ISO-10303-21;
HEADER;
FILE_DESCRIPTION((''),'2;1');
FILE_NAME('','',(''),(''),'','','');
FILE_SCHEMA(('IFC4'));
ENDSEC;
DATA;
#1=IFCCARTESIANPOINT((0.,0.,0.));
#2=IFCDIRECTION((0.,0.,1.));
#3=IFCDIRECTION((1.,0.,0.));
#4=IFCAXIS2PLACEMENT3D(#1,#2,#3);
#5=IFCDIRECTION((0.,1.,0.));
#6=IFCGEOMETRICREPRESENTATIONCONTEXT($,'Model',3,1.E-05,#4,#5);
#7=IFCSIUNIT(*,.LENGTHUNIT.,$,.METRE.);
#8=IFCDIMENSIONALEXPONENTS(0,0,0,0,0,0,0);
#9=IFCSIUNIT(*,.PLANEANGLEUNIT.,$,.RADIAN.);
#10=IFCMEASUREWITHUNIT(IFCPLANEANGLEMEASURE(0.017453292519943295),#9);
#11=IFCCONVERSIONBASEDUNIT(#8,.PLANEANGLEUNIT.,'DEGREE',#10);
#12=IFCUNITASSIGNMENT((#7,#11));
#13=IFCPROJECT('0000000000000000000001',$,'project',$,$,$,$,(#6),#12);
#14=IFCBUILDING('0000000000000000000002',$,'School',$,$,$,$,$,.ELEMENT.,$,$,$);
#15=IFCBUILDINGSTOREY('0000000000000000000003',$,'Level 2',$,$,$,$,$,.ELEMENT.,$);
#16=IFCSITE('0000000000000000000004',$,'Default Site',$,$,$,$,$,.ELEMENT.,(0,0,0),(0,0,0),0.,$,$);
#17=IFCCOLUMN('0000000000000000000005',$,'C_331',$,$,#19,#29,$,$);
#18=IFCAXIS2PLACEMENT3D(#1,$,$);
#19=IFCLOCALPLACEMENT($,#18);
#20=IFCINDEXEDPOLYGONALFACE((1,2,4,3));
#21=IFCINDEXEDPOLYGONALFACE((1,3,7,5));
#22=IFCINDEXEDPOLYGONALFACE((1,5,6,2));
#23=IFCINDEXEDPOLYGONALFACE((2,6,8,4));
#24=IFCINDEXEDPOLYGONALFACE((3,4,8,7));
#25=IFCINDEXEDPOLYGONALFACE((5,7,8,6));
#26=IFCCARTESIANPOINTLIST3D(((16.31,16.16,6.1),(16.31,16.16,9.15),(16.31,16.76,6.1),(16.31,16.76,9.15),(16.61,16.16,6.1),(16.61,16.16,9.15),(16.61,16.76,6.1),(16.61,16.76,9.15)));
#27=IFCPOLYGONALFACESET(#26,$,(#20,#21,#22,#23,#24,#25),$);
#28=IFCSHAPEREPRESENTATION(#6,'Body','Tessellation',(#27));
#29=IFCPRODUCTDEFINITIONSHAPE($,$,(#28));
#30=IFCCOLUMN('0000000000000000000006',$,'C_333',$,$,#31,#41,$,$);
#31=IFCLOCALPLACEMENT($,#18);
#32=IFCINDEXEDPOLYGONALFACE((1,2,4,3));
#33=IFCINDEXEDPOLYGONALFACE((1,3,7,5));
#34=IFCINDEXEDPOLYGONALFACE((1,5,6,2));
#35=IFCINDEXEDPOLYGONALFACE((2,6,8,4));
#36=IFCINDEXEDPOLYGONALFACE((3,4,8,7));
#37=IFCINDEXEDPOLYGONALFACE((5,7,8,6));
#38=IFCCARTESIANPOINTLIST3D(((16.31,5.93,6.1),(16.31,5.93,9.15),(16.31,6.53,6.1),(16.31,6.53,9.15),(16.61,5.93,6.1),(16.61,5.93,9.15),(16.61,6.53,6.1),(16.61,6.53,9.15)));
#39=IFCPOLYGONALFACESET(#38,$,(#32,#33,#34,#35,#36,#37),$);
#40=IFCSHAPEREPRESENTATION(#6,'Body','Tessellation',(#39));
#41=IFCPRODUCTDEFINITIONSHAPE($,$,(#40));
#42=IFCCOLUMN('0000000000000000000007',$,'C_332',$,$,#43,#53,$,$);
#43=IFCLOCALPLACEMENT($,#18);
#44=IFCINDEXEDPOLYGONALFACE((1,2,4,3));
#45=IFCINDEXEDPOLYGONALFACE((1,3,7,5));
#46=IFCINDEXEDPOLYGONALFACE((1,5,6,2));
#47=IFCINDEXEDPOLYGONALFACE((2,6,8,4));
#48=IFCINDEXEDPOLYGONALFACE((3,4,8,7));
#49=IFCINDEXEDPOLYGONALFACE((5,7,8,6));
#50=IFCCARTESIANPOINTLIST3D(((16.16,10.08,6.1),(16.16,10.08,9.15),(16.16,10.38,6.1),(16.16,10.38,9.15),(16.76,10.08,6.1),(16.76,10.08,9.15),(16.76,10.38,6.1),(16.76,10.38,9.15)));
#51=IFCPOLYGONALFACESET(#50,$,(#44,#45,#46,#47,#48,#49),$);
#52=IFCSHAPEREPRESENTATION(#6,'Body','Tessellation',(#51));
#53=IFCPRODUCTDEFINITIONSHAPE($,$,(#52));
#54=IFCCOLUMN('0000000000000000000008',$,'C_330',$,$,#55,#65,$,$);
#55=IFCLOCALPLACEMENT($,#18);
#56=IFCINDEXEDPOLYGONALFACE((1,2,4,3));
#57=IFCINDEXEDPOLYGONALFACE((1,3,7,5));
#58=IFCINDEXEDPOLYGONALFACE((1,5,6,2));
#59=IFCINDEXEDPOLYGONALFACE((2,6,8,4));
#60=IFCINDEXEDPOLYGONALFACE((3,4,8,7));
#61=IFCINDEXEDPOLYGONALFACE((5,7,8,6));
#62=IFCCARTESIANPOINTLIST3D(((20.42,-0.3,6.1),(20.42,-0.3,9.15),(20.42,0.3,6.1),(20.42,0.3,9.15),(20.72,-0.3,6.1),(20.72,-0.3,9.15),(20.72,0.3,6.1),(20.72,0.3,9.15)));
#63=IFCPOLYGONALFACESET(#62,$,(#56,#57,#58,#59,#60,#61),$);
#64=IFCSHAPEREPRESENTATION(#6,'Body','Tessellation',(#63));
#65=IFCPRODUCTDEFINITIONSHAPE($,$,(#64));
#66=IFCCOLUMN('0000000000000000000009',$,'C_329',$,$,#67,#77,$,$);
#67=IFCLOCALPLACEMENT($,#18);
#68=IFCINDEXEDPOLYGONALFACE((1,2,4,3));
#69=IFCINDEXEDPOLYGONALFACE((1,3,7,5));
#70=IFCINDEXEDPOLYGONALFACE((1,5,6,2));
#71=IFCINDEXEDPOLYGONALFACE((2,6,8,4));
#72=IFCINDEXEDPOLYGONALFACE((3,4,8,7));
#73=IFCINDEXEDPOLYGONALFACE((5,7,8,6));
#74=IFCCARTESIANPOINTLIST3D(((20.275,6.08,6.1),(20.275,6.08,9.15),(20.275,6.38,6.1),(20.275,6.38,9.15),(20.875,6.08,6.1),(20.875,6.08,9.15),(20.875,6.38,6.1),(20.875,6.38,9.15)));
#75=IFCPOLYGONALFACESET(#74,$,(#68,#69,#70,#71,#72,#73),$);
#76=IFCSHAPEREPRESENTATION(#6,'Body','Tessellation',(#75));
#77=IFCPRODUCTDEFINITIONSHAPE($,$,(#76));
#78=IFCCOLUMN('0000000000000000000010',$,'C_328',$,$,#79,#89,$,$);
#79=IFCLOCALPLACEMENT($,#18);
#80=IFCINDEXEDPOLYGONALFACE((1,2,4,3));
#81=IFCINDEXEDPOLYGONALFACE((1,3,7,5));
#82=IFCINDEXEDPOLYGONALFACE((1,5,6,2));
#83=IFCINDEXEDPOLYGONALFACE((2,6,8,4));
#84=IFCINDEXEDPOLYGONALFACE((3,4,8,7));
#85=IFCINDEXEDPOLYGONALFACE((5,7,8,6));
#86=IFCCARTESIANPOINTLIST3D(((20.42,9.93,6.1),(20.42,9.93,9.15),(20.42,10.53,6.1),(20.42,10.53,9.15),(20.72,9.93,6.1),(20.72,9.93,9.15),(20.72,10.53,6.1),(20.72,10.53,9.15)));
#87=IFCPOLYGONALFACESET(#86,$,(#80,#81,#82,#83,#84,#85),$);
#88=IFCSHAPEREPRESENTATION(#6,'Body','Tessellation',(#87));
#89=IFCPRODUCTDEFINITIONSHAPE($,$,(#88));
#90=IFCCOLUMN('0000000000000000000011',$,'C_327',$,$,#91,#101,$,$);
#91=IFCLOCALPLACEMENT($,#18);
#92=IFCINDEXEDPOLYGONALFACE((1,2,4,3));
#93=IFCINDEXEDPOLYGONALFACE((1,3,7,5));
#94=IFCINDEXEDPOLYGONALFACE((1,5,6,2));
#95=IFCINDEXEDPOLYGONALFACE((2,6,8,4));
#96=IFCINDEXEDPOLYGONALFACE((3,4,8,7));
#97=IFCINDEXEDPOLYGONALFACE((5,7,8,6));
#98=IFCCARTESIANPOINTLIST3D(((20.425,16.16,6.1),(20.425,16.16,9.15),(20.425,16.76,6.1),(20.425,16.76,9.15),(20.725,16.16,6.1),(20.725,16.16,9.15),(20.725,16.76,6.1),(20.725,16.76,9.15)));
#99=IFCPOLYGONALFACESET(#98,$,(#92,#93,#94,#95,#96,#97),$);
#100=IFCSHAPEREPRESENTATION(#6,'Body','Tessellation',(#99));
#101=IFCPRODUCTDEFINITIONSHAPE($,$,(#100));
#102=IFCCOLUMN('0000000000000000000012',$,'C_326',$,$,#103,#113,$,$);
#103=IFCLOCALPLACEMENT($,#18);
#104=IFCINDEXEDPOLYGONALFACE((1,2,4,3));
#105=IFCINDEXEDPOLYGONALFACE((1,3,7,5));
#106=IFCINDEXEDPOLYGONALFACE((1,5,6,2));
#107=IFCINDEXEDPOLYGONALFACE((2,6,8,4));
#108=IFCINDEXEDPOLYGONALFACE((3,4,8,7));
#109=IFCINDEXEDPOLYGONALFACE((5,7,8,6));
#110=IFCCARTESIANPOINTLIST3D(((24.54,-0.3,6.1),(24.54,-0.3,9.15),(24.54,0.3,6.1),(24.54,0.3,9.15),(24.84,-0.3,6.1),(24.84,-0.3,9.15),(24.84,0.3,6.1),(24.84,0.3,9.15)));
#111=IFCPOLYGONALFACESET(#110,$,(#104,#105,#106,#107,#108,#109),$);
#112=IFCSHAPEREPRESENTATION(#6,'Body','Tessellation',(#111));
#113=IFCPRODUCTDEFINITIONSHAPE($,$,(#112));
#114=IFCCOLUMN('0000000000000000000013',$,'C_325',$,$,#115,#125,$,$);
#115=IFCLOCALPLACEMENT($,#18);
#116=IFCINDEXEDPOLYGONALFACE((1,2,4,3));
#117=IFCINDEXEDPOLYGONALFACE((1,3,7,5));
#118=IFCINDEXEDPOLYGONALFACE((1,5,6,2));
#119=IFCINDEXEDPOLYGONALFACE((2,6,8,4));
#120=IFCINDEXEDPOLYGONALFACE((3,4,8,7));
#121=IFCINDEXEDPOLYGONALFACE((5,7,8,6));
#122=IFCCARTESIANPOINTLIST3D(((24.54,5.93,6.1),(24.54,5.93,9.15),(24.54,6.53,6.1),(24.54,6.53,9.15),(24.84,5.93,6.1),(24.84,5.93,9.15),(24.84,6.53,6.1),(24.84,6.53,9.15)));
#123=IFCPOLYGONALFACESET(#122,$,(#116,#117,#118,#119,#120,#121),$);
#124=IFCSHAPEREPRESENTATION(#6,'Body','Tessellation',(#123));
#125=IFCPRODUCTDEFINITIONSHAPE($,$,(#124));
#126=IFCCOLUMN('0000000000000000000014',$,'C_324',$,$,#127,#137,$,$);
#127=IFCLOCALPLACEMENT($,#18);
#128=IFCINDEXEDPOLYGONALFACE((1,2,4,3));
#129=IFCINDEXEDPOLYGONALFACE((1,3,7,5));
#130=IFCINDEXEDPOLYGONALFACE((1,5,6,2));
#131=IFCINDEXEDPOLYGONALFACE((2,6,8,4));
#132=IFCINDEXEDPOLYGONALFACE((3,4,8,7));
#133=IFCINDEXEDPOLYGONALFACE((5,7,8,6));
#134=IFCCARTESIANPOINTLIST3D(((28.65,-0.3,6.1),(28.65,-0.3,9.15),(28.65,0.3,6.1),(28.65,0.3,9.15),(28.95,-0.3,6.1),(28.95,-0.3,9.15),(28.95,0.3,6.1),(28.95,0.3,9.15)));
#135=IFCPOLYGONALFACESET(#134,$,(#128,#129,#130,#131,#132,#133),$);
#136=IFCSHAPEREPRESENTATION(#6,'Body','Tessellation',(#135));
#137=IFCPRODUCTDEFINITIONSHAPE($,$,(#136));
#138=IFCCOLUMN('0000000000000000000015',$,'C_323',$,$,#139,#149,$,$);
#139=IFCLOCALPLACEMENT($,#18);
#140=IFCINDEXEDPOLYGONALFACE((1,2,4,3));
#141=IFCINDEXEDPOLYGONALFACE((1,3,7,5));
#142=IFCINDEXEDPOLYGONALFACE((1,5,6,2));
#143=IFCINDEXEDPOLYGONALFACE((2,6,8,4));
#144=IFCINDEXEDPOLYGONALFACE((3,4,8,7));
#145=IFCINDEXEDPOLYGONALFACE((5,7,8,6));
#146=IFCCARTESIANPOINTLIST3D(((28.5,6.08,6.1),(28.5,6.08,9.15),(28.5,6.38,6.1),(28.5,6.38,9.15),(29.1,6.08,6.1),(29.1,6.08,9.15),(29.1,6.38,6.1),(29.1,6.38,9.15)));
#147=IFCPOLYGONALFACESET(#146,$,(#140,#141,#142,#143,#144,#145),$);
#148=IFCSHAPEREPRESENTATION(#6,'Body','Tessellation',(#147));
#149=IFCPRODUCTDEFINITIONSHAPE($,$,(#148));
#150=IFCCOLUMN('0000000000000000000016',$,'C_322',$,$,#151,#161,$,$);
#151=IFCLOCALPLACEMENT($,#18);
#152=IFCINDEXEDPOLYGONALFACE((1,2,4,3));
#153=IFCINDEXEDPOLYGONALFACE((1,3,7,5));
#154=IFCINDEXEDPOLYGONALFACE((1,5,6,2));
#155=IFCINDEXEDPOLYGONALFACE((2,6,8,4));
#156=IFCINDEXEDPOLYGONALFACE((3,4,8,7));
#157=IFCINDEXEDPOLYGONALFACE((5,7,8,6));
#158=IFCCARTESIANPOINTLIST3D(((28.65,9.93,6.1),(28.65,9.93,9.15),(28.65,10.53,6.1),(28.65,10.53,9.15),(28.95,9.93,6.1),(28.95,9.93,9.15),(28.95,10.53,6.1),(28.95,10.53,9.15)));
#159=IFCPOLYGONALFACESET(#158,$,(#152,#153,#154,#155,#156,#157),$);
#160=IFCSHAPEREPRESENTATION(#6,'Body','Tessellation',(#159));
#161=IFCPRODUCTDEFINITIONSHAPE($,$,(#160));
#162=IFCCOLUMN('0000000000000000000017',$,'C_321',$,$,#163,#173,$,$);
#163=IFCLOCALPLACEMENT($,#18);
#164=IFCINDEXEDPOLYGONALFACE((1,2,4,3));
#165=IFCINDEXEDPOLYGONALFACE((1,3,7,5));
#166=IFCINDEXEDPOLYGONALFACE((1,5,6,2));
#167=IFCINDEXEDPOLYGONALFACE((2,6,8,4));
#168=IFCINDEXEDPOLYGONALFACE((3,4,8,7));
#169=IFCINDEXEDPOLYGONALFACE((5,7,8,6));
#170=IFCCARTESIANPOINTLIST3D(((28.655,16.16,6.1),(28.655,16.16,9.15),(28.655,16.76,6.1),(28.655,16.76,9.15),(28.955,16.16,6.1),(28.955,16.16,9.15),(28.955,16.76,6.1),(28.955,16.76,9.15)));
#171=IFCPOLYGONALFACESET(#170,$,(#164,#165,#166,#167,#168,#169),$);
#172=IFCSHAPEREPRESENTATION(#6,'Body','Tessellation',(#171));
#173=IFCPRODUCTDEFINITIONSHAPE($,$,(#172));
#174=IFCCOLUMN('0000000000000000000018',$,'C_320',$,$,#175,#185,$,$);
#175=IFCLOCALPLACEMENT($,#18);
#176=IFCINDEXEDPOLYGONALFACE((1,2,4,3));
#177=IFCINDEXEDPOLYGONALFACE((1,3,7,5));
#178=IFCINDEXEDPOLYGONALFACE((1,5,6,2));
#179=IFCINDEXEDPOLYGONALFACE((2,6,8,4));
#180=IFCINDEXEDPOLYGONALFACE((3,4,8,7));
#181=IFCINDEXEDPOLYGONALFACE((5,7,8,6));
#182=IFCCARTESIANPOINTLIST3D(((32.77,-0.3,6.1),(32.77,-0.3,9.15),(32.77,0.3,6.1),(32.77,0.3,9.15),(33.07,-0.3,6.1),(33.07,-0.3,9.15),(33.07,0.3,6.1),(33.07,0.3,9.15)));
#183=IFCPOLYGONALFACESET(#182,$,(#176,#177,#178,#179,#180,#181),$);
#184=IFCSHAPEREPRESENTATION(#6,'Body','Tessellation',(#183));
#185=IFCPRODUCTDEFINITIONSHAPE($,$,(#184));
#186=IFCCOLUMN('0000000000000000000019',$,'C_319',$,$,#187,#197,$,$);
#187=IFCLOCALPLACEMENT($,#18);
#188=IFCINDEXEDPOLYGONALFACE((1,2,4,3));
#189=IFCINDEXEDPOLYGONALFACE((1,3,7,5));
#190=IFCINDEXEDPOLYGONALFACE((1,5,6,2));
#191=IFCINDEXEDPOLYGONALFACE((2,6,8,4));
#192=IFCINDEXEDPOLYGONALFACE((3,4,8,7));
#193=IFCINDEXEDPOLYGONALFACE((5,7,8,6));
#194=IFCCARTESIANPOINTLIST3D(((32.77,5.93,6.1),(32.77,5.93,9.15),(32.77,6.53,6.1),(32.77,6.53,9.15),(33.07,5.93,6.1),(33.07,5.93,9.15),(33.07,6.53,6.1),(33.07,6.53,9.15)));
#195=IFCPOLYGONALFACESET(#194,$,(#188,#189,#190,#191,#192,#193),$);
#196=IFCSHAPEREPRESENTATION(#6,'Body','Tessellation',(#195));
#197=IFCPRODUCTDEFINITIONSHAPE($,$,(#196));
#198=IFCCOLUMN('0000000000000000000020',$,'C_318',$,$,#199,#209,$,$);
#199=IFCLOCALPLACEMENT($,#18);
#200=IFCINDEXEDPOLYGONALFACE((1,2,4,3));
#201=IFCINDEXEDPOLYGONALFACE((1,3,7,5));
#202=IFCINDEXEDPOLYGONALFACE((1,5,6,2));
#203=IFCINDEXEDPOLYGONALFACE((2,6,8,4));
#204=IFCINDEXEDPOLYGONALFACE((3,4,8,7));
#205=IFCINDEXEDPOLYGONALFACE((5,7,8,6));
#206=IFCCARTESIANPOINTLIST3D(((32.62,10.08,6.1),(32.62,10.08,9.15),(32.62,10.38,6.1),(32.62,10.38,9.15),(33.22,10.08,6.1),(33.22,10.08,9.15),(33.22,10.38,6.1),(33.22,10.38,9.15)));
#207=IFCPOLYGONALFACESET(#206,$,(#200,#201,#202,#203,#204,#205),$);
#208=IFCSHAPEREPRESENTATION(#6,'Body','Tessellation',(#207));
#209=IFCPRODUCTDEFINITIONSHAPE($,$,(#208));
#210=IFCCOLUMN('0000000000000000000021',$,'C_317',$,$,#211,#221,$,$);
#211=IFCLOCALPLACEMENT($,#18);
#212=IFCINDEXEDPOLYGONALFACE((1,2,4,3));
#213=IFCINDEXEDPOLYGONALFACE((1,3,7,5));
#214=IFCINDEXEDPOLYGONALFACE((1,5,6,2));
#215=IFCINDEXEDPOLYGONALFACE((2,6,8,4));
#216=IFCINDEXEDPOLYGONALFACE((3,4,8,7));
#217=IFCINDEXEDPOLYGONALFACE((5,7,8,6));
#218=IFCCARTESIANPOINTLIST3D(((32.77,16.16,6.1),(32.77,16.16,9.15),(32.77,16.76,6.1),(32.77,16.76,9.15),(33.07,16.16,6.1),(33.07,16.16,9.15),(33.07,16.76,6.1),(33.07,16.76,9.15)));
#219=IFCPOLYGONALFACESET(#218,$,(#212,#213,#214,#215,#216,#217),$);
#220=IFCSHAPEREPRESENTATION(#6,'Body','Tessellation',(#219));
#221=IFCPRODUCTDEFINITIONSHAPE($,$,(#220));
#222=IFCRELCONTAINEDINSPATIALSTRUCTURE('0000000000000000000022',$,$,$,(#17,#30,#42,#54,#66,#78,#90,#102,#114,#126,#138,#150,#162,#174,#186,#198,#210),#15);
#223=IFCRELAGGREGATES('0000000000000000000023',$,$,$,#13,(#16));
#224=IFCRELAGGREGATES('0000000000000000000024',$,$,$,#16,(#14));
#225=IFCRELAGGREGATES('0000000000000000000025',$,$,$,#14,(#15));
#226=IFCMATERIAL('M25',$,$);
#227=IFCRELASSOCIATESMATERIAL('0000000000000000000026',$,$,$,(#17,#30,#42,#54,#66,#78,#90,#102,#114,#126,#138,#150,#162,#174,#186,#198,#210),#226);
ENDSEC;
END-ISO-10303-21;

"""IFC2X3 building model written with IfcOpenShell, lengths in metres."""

from ifc_helpers import new_model, entity, si_unit, converted_unit, direction, frame, frame_2d, origin_with_axes, place, context, project, spatial, rectangle, extrude, material, element, save


model = new_model("IFC2X3")

# Units and contexts
model_context = context("Model", 3, precision=1e-05, world=origin_with_axes(), true_north=direction((0.0, 1.0, 0.0)))
ifc_project = project(units=[si_unit("LENGTHUNIT", "METRE"), converted_unit("PLANEANGLEUNIT", "DEGREE", entity("IfcPlaneAngleMeasure", 0.017453292519943295), si_unit("PLANEANGLEUNIT", "RADIAN"), dimensions=[0, 0, 0, 0, 0, 0, 0])], contexts=[model_context])

# Site, building, storey
site = spatial("IfcSite", under=ifc_project, Name="Default Site", CompositionType="ELEMENT", RefLatitude=(0, 0, 0), RefLongitude=(0, 0, 0), RefElevation=0.0)
building = spatial("IfcBuilding", under=site, Name="School", CompositionType="ELEMENT")
storey = spatial("IfcBuildingStorey", under=building, Name="Level 2", CompositionType="ELEMENT")

# Columns
ifc_material = material(Name="M25")
placement = place(None, origin_with_axes())
element("IfcColumn", 1, at=placement, inside=storey, material=ifc_material, Name="C_331", context=model_context, shape_type="SweptSolid", body=[
    extrude(rectangle(XDim=0.3, YDim=0.6, at=frame_2d((0.0, 0.0), x_axis=(1.0, 0.0, 0.0))), frame((16.46, 16.46, 6.1), z_axis=(0.0, 0.0, 1.0), x_axis=(1.0, 0.0, 0.0)), (0.0, 0.0, 1.0), 3.05),
])
element("IfcColumn", 2, at=placement, inside=storey, material=ifc_material, Name="C_333", context=model_context, shape_type="SweptSolid", body=[
    extrude(rectangle(XDim=0.3, YDim=0.6, at=frame_2d((0.0, 0.0), x_axis=(1.0, 0.0, 0.0))), frame((16.46, 6.23, 6.1), z_axis=(0.0, 0.0, 1.0), x_axis=(1.0, 0.0, 0.0)), (0.0, 0.0, 1.0), 3.05),
])
element("IfcColumn", 3, at=placement, inside=storey, material=ifc_material, Name="C_332", context=model_context, shape_type="SweptSolid", body=[
    extrude(rectangle(XDim=0.6, YDim=0.3, at=frame_2d((0.0, 0.0), x_axis=(1.0, 0.0, 0.0))), frame((16.46, 10.23, 6.1), z_axis=(0.0, 0.0, 1.0), x_axis=(1.0, 0.0, 0.0)), (0.0, 0.0, 1.0), 3.05),
])
element("IfcColumn", 4, at=placement, inside=storey, material=ifc_material, Name="C_330", context=model_context, shape_type="SweptSolid", body=[
    extrude(rectangle(XDim=0.3, YDim=0.6, at=frame_2d((0.0, 0.0), x_axis=(1.0, 0.0, 0.0))), frame((20.57, 0.0, 6.1), z_axis=(0.0, 0.0, 1.0), x_axis=(1.0, 0.0, 0.0)), (0.0, 0.0, 1.0), 3.05),
])
element("IfcColumn", 5, at=placement, inside=storey, material=ifc_material, Name="C_329", context=model_context, shape_type="SweptSolid", body=[
    extrude(rectangle(XDim=0.6, YDim=0.3, at=frame_2d((0.0, 0.0), x_axis=(1.0, 0.0, 0.0))), frame((20.575, 6.23, 6.1), z_axis=(0.0, 0.0, 1.0), x_axis=(1.0, 0.0, 0.0)), (0.0, 0.0, 1.0), 3.05),
])
element("IfcColumn", 6, at=placement, inside=storey, material=ifc_material, Name="C_328", context=model_context, shape_type="SweptSolid", body=[
    extrude(rectangle(XDim=0.3, YDim=0.6, at=frame_2d((0.0, 0.0), x_axis=(1.0, 0.0, 0.0))), frame((20.57, 10.23, 6.1), z_axis=(0.0, 0.0, 1.0), x_axis=(1.0, 0.0, 0.0)), (0.0, 0.0, 1.0), 3.05),
])
element("IfcColumn", 7, at=placement, inside=storey, material=ifc_material, Name="C_327", context=model_context, shape_type="SweptSolid", body=[
    extrude(rectangle(XDim=0.3, YDim=0.6, at=frame_2d((0.0, 0.0), x_axis=(1.0, 0.0, 0.0))), frame((20.575, 16.46, 6.1), z_axis=(0.0, 0.0, 1.0), x_axis=(1.0, 0.0, 0.0)), (0.0, 0.0, 1.0), 3.05),
])
element("IfcColumn", 8, at=placement, inside=storey, material=ifc_material, Name="C_326", context=model_context, shape_type="SweptSolid", body=[
    extrude(rectangle(XDim=0.3, YDim=0.6, at=frame_2d((0.0, 0.0), x_axis=(1.0, 0.0, 0.0))), frame((24.69, 0.0, 6.1), z_axis=(0.0, 0.0, 1.0), x_axis=(1.0, 0.0, 0.0)), (0.0, 0.0, 1.0), 3.05),
])
element("IfcColumn", 9, at=placement, inside=storey, material=ifc_material, Name="C_325", context=model_context, shape_type="SweptSolid", body=[
    extrude(rectangle(XDim=0.3, YDim=0.6, at=frame_2d((0.0, 0.0), x_axis=(1.0, 0.0, 0.0))), frame((24.69, 6.23, 6.1), z_axis=(0.0, 0.0, 1.0), x_axis=(1.0, 0.0, 0.0)), (0.0, 0.0, 1.0), 3.05),
])
element("IfcColumn", 10, at=placement, inside=storey, material=ifc_material, Name="C_324", context=model_context, shape_type="SweptSolid", body=[
    extrude(rectangle(XDim=0.3, YDim=0.6, at=frame_2d((0.0, 0.0), x_axis=(1.0, 0.0, 0.0))), frame((28.8, 0.0, 6.1), z_axis=(0.0, 0.0, 1.0), x_axis=(1.0, 0.0, 0.0)), (0.0, 0.0, 1.0), 3.05),
])
element("IfcColumn", 11, at=placement, inside=storey, material=ifc_material, Name="C_323", context=model_context, shape_type="SweptSolid", body=[
    extrude(rectangle(XDim=0.6, YDim=0.3, at=frame_2d((0.0, 0.0), x_axis=(1.0, 0.0, 0.0))), frame((28.8, 6.23, 6.1), z_axis=(0.0, 0.0, 1.0), x_axis=(1.0, 0.0, 0.0)), (0.0, 0.0, 1.0), 3.05),
])
element("IfcColumn", 12, at=placement, inside=storey, material=ifc_material, Name="C_322", context=model_context, shape_type="SweptSolid", body=[
    extrude(rectangle(XDim=0.3, YDim=0.6, at=frame_2d((0.0, 0.0), x_axis=(1.0, 0.0, 0.0))), frame((28.8, 10.23, 6.1), z_axis=(0.0, 0.0, 1.0), x_axis=(1.0, 0.0, 0.0)), (0.0, 0.0, 1.0), 3.05),
])
element("IfcColumn", 13, at=placement, inside=storey, material=ifc_material, Name="C_321", context=model_context, shape_type="SweptSolid", body=[
    extrude(rectangle(XDim=0.3, YDim=0.6, at=frame_2d((0.0, 0.0), x_axis=(1.0, 0.0, 0.0))), frame((28.805, 16.46, 6.1), z_axis=(0.0, 0.0, 1.0), x_axis=(1.0, 0.0, 0.0)), (0.0, 0.0, 1.0), 3.05),
])
element("IfcColumn", 14, at=placement, inside=storey, material=ifc_material, Name="C_320", context=model_context, shape_type="SweptSolid", body=[
    extrude(rectangle(XDim=0.3, YDim=0.6, at=frame_2d((0.0, 0.0), x_axis=(1.0, 0.0, 0.0))), frame((32.92, 0.0, 6.1), z_axis=(0.0, 0.0, 1.0), x_axis=(1.0, 0.0, 0.0)), (0.0, 0.0, 1.0), 3.05),
])
element("IfcColumn", 15, at=placement, inside=storey, material=ifc_material, Name="C_319", context=model_context, shape_type="SweptSolid", body=[
    extrude(rectangle(XDim=0.3, YDim=0.6, at=frame_2d((0.0, 0.0), x_axis=(1.0, 0.0, 0.0))), frame((32.92, 6.23, 6.1), z_axis=(0.0, 0.0, 1.0), x_axis=(1.0, 0.0, 0.0)), (0.0, 0.0, 1.0), 3.05),
])
element("IfcColumn", 16, at=placement, inside=storey, material=ifc_material, Name="C_318", context=model_context, shape_type="SweptSolid", body=[
    extrude(rectangle(XDim=0.6, YDim=0.3, at=frame_2d((0.0, 0.0), x_axis=(1.0, 0.0, 0.0))), frame((32.92, 10.23, 6.1), z_axis=(0.0, 0.0, 1.0), x_axis=(1.0, 0.0, 0.0)), (0.0, 0.0, 1.0), 3.05),
])
element("IfcColumn", 17, at=placement, inside=storey, material=ifc_material, Name="C_317", context=model_context, shape_type="SweptSolid", body=[
    extrude(rectangle(XDim=0.3, YDim=0.6, at=frame_2d((0.0, 0.0), x_axis=(1.0, 0.0, 0.0))), frame((32.92, 16.46, 6.1), z_axis=(0.0, 0.0, 1.0), x_axis=(1.0, 0.0, 0.0)), (0.0, 0.0, 1.0), 3.05),
])

save(model, "model.ifc")
